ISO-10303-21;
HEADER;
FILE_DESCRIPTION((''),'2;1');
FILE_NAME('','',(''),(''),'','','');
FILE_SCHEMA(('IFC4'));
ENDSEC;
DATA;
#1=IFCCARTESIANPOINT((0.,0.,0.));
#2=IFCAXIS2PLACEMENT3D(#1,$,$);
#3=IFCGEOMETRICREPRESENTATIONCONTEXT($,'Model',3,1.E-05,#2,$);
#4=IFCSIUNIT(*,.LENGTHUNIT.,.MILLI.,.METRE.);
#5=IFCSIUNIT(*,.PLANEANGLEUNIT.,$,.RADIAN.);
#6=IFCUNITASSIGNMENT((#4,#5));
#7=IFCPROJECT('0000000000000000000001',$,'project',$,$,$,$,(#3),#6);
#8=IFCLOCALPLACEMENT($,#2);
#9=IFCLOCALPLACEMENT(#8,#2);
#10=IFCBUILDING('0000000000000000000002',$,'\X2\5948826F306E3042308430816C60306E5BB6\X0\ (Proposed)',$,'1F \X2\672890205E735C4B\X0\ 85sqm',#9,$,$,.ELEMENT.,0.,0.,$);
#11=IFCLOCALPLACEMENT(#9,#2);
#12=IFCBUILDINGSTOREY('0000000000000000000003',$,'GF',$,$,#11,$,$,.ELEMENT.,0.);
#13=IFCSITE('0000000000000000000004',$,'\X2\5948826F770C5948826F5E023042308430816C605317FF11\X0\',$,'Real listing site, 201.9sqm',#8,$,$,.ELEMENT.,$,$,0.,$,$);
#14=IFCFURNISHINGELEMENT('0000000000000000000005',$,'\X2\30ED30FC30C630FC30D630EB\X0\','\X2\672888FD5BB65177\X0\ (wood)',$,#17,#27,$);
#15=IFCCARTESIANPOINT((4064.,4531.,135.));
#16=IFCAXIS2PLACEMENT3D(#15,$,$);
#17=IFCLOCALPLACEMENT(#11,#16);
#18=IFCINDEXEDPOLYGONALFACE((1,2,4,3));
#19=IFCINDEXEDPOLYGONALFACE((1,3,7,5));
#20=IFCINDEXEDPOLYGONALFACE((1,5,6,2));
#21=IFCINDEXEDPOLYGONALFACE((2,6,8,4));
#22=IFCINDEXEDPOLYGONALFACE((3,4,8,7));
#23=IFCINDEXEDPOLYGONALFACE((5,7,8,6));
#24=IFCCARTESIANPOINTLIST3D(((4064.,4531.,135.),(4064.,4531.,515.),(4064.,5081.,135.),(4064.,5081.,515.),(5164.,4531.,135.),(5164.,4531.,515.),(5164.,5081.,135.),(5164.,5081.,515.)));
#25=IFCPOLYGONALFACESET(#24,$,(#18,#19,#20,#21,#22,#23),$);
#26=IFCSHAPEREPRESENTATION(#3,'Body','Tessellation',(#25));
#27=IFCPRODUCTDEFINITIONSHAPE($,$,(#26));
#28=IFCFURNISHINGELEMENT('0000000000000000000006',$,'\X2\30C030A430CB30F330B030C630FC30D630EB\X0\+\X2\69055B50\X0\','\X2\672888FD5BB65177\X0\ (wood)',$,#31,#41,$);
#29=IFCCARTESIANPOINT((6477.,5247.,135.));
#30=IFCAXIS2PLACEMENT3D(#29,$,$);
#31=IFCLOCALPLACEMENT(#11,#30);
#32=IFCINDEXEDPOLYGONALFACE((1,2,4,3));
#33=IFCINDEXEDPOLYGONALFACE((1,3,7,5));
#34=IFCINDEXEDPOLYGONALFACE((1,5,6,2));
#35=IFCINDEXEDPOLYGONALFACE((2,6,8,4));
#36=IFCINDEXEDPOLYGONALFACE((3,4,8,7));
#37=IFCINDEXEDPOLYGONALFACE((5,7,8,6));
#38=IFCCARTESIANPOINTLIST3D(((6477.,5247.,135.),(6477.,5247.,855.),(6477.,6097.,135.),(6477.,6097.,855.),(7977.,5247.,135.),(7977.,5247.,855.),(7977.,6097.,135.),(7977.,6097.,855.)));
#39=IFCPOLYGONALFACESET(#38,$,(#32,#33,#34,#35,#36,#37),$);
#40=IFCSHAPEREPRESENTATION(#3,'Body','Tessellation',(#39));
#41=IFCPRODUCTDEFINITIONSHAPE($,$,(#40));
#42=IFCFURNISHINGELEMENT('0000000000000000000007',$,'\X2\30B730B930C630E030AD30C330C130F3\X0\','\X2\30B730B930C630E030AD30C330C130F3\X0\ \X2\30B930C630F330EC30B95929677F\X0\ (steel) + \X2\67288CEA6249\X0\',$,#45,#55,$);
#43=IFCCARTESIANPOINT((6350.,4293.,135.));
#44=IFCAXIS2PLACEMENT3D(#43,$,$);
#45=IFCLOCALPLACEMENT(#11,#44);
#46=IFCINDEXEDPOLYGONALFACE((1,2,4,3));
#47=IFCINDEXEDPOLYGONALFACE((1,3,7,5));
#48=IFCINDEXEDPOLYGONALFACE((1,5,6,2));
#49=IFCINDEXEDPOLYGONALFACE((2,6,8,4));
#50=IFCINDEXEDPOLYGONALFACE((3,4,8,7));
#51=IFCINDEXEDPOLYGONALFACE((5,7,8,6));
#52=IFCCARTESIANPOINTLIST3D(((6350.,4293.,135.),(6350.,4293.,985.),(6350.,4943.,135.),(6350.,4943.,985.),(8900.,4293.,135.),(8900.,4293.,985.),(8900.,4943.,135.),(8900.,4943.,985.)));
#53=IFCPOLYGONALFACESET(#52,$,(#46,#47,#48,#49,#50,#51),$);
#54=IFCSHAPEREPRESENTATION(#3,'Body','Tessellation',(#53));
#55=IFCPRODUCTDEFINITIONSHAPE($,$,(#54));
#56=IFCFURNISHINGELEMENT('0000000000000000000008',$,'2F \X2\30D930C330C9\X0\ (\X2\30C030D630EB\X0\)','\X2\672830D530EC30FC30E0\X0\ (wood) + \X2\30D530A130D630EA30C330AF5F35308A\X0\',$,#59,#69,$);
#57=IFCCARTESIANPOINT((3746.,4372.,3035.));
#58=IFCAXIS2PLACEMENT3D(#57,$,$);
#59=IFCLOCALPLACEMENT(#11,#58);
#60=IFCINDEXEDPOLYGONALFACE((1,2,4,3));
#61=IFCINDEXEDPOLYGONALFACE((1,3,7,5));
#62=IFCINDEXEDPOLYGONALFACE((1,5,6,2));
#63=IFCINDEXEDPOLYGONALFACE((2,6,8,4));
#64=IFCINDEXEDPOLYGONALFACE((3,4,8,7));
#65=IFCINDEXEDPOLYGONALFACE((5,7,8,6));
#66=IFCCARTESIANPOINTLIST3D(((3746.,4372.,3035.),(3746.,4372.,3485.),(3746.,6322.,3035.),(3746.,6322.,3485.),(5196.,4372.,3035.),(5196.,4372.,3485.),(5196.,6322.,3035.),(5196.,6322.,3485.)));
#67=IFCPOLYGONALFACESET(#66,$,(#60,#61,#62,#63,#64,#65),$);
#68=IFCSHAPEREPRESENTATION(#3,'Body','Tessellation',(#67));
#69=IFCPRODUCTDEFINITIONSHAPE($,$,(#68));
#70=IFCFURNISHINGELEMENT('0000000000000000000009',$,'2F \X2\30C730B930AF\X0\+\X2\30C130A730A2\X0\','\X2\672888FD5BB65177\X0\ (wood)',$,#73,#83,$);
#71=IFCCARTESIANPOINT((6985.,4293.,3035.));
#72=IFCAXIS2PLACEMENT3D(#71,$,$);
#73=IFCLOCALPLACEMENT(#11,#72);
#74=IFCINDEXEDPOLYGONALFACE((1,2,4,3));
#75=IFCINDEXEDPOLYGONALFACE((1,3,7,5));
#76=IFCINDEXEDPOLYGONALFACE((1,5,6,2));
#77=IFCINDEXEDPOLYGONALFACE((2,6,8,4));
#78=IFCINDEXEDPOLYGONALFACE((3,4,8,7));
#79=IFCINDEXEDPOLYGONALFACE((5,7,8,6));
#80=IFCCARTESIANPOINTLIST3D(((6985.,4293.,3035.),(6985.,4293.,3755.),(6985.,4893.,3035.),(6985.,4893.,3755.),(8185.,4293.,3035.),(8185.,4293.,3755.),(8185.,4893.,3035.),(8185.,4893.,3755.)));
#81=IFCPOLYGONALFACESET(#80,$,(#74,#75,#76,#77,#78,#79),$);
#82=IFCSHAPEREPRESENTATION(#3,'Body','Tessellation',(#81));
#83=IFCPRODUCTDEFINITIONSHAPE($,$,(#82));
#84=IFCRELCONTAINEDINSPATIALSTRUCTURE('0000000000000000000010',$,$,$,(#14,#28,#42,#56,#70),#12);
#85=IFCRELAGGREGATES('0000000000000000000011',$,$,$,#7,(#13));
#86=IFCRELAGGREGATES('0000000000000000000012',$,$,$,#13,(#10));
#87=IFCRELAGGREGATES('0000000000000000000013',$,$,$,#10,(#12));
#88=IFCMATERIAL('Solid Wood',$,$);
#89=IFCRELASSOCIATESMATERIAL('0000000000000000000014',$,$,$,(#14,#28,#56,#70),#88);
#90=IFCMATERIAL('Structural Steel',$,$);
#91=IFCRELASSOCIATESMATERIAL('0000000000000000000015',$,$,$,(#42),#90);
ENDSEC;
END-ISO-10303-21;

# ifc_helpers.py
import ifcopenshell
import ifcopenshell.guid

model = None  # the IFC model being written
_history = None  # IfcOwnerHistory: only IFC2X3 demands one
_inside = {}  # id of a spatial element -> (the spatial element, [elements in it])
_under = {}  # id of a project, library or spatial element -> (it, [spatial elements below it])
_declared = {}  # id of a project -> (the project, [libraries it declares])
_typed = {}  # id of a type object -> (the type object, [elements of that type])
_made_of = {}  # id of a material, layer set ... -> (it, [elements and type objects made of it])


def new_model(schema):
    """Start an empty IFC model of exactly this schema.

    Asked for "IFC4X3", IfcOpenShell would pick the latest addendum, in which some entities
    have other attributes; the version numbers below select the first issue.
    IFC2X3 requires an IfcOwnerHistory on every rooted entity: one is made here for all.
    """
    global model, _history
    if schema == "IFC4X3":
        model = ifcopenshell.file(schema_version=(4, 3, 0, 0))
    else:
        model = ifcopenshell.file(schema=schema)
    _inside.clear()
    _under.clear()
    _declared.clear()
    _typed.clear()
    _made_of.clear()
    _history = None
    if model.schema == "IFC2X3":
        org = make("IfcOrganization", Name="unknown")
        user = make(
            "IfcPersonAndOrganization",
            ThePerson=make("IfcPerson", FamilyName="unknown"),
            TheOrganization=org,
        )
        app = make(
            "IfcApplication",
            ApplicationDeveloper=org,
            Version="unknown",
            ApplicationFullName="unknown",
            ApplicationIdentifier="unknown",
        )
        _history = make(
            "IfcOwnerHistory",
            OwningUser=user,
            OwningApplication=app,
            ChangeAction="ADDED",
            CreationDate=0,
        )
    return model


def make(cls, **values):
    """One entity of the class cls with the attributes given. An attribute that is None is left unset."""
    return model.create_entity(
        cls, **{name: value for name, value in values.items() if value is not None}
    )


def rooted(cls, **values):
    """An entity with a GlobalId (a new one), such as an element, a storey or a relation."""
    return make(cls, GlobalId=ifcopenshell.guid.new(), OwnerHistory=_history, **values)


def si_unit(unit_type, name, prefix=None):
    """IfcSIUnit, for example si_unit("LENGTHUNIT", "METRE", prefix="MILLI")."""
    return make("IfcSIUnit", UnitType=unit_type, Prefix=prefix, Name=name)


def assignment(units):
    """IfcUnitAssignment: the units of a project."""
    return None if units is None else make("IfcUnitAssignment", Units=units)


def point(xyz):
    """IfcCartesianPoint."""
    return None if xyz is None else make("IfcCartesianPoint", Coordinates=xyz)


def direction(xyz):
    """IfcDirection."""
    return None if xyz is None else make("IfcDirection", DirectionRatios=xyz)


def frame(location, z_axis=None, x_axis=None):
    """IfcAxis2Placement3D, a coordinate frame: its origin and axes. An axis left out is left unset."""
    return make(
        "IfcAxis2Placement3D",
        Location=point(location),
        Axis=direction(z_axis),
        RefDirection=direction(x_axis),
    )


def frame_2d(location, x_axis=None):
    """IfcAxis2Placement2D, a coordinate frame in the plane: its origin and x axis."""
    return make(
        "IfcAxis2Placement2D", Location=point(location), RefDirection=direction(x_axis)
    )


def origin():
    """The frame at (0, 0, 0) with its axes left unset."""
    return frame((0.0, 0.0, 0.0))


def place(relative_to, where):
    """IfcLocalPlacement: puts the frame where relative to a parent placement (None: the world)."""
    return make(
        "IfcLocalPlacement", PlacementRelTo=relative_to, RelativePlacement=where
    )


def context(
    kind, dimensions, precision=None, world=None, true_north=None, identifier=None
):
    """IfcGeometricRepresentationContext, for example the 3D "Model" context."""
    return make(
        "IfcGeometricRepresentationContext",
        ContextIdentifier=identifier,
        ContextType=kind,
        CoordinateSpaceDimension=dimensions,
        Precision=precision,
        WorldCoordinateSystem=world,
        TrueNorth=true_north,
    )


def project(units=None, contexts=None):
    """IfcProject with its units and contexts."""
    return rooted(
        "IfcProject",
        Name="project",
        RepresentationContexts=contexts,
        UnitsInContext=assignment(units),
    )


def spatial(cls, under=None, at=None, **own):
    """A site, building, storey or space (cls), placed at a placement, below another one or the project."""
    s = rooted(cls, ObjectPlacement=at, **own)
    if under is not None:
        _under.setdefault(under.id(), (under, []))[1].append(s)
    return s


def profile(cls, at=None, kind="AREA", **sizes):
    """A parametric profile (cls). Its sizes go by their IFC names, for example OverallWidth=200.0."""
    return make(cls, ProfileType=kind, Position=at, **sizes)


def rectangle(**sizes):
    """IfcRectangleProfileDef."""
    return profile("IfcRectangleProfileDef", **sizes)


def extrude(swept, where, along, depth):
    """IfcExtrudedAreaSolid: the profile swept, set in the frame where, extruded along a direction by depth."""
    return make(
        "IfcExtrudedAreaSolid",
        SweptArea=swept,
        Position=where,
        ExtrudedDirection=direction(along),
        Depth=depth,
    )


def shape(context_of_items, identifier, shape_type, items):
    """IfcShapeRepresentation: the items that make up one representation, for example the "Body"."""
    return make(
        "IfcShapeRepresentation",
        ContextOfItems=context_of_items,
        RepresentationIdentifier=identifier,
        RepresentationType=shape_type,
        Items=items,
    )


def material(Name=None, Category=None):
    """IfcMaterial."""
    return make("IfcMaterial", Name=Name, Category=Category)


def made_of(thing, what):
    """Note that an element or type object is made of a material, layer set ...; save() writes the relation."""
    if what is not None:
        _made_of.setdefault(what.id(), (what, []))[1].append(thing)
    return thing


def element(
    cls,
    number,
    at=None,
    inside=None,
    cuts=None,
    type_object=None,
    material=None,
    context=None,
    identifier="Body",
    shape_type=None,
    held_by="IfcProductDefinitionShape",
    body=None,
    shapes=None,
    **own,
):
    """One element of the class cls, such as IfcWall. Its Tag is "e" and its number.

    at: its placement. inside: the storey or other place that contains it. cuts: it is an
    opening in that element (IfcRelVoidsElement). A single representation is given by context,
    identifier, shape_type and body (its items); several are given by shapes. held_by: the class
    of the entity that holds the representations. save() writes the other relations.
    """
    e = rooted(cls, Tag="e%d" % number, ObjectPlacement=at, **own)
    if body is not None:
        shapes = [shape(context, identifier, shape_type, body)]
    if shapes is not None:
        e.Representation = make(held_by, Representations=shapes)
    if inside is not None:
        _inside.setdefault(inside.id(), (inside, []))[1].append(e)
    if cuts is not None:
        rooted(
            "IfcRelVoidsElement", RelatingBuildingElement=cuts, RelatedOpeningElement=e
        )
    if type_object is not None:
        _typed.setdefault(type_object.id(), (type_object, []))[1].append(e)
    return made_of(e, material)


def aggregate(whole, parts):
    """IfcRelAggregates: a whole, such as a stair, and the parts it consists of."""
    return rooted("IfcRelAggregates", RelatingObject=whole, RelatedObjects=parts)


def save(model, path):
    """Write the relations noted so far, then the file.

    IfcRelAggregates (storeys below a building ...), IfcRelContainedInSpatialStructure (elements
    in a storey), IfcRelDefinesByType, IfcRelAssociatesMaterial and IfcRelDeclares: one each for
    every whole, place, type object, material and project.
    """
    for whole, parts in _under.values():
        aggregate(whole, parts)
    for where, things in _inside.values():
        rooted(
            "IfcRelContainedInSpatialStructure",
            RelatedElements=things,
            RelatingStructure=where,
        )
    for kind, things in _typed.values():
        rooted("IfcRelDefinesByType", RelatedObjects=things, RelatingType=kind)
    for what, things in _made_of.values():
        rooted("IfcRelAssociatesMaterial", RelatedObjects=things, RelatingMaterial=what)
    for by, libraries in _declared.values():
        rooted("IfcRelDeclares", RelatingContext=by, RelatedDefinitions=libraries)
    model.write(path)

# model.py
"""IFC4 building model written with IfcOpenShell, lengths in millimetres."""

from ifc_helpers import new_model, si_unit, frame, frame_2d, origin, place, context, project, spatial, rectangle, extrude, material, element, save


model = new_model("IFC4")

# Units and contexts
model_context = context("Model", 3, precision=1e-05, world=origin())
ifc_project = project(units=[si_unit("LENGTHUNIT", "METRE", prefix="MILLI"), si_unit("PLANEANGLEUNIT", "RADIAN")], contexts=[model_context])

# Site, building, storey
site_placement = place(None, origin())
site = spatial("IfcSite", under=ifc_project, at=site_placement, Name="奈良県奈良市あやめ池北１", ObjectType="Real listing site, 201.9sqm", CompositionType="ELEMENT", RefElevation=0.0)
building_placement = place(site_placement, origin())
building = spatial("IfcBuilding", under=site, at=building_placement, Name="奈良のあやめ池の家 (Proposed)", ObjectType="1F 木造平屋 85sqm", CompositionType="ELEMENT", ElevationOfRefHeight=0.0, ElevationOfTerrain=0.0)
storey_placement = place(building_placement, origin())
storey = spatial("IfcBuildingStorey", under=building, at=storey_placement, Name="GF", CompositionType="ELEMENT", Elevation=0.0)

# Shared definitions
ifc_material_1 = material(Name="Solid Wood")

# Shared definitions
ifc_material_2 = material(Name="Structural Steel")

# Furnishing elements
furnishing_1_placement = place(storey_placement, frame((4064.0, 4531.0, 135.0)))
element("IfcFurnishingElement", 1, at=furnishing_1_placement, inside=storey, material=ifc_material_1, Name="ローテーブル", Description="木製家具 (wood)", context=model_context, shape_type="SweptSolid", body=[
    extrude(rectangle(XDim=1100.0, YDim=550.0, at=frame_2d((550.0, 275.0))), frame((4064.0, 4531.0, 135.0)), (0.0, 0.0, 1.0), 380.0),
])
furnishing_2_placement = place(storey_placement, frame((6477.0, 5247.0, 135.0)))
element("IfcFurnishingElement", 2, at=furnishing_2_placement, inside=storey, material=ifc_material_1, Name="ダイニングテーブル+椅子", Description="木製家具 (wood)", context=model_context, shape_type="SweptSolid", body=[
    extrude(rectangle(XDim=1500.0, YDim=850.0, at=frame_2d((750.0, 425.0))), frame((6477.0, 5247.0, 135.0)), (0.0, 0.0, 1.0), 720.0),
])
furnishing_3_placement = place(storey_placement, frame((6350.0, 4293.0, 135.0)))
element("IfcFurnishingElement", 3, at=furnishing_3_placement, inside=storey, material=ifc_material_2, Name="システムキッチン", Description="システムキッチン ステンレス天板 (steel) + 木質扉", context=model_context, shape_type="SweptSolid", body=[
    extrude(rectangle(XDim=2550.0, YDim=650.0, at=frame_2d((1275.0, 325.0))), frame((6350.0, 4293.0, 135.0)), (0.0, 0.0, 1.0), 850.0),
])
furnishing_4_placement = place(storey_placement, frame((3746.0, 4372.0, 3035.0)))
element("IfcFurnishingElement", 4, at=furnishing_4_placement, inside=storey, material=ifc_material_1, Name="2F ベッド (ダブル)", Description="木フレーム (wood) + ファブリック張り", context=model_context, shape_type="SweptSolid", body=[
    extrude(rectangle(XDim=1450.0, YDim=1950.0, at=frame_2d((725.0, 975.0))), frame((3746.0, 4372.0, 3035.0)), (0.0, 0.0, 1.0), 450.0),
])
furnishing_5_placement = place(storey_placement, frame((6985.0, 4293.0, 3035.0)))
element("IfcFurnishingElement", 5, at=furnishing_5_placement, inside=storey, material=ifc_material_1, Name="2F デスク+チェア", Description="木製家具 (wood)", context=model_context, shape_type="SweptSolid", body=[
    extrude(rectangle(XDim=1200.0, YDim=600.0, at=frame_2d((600.0, 300.0))), frame((6985.0, 4293.0, 3035.0)), (0.0, 0.0, 1.0), 720.0),
])

save(model, "model.ifc")
